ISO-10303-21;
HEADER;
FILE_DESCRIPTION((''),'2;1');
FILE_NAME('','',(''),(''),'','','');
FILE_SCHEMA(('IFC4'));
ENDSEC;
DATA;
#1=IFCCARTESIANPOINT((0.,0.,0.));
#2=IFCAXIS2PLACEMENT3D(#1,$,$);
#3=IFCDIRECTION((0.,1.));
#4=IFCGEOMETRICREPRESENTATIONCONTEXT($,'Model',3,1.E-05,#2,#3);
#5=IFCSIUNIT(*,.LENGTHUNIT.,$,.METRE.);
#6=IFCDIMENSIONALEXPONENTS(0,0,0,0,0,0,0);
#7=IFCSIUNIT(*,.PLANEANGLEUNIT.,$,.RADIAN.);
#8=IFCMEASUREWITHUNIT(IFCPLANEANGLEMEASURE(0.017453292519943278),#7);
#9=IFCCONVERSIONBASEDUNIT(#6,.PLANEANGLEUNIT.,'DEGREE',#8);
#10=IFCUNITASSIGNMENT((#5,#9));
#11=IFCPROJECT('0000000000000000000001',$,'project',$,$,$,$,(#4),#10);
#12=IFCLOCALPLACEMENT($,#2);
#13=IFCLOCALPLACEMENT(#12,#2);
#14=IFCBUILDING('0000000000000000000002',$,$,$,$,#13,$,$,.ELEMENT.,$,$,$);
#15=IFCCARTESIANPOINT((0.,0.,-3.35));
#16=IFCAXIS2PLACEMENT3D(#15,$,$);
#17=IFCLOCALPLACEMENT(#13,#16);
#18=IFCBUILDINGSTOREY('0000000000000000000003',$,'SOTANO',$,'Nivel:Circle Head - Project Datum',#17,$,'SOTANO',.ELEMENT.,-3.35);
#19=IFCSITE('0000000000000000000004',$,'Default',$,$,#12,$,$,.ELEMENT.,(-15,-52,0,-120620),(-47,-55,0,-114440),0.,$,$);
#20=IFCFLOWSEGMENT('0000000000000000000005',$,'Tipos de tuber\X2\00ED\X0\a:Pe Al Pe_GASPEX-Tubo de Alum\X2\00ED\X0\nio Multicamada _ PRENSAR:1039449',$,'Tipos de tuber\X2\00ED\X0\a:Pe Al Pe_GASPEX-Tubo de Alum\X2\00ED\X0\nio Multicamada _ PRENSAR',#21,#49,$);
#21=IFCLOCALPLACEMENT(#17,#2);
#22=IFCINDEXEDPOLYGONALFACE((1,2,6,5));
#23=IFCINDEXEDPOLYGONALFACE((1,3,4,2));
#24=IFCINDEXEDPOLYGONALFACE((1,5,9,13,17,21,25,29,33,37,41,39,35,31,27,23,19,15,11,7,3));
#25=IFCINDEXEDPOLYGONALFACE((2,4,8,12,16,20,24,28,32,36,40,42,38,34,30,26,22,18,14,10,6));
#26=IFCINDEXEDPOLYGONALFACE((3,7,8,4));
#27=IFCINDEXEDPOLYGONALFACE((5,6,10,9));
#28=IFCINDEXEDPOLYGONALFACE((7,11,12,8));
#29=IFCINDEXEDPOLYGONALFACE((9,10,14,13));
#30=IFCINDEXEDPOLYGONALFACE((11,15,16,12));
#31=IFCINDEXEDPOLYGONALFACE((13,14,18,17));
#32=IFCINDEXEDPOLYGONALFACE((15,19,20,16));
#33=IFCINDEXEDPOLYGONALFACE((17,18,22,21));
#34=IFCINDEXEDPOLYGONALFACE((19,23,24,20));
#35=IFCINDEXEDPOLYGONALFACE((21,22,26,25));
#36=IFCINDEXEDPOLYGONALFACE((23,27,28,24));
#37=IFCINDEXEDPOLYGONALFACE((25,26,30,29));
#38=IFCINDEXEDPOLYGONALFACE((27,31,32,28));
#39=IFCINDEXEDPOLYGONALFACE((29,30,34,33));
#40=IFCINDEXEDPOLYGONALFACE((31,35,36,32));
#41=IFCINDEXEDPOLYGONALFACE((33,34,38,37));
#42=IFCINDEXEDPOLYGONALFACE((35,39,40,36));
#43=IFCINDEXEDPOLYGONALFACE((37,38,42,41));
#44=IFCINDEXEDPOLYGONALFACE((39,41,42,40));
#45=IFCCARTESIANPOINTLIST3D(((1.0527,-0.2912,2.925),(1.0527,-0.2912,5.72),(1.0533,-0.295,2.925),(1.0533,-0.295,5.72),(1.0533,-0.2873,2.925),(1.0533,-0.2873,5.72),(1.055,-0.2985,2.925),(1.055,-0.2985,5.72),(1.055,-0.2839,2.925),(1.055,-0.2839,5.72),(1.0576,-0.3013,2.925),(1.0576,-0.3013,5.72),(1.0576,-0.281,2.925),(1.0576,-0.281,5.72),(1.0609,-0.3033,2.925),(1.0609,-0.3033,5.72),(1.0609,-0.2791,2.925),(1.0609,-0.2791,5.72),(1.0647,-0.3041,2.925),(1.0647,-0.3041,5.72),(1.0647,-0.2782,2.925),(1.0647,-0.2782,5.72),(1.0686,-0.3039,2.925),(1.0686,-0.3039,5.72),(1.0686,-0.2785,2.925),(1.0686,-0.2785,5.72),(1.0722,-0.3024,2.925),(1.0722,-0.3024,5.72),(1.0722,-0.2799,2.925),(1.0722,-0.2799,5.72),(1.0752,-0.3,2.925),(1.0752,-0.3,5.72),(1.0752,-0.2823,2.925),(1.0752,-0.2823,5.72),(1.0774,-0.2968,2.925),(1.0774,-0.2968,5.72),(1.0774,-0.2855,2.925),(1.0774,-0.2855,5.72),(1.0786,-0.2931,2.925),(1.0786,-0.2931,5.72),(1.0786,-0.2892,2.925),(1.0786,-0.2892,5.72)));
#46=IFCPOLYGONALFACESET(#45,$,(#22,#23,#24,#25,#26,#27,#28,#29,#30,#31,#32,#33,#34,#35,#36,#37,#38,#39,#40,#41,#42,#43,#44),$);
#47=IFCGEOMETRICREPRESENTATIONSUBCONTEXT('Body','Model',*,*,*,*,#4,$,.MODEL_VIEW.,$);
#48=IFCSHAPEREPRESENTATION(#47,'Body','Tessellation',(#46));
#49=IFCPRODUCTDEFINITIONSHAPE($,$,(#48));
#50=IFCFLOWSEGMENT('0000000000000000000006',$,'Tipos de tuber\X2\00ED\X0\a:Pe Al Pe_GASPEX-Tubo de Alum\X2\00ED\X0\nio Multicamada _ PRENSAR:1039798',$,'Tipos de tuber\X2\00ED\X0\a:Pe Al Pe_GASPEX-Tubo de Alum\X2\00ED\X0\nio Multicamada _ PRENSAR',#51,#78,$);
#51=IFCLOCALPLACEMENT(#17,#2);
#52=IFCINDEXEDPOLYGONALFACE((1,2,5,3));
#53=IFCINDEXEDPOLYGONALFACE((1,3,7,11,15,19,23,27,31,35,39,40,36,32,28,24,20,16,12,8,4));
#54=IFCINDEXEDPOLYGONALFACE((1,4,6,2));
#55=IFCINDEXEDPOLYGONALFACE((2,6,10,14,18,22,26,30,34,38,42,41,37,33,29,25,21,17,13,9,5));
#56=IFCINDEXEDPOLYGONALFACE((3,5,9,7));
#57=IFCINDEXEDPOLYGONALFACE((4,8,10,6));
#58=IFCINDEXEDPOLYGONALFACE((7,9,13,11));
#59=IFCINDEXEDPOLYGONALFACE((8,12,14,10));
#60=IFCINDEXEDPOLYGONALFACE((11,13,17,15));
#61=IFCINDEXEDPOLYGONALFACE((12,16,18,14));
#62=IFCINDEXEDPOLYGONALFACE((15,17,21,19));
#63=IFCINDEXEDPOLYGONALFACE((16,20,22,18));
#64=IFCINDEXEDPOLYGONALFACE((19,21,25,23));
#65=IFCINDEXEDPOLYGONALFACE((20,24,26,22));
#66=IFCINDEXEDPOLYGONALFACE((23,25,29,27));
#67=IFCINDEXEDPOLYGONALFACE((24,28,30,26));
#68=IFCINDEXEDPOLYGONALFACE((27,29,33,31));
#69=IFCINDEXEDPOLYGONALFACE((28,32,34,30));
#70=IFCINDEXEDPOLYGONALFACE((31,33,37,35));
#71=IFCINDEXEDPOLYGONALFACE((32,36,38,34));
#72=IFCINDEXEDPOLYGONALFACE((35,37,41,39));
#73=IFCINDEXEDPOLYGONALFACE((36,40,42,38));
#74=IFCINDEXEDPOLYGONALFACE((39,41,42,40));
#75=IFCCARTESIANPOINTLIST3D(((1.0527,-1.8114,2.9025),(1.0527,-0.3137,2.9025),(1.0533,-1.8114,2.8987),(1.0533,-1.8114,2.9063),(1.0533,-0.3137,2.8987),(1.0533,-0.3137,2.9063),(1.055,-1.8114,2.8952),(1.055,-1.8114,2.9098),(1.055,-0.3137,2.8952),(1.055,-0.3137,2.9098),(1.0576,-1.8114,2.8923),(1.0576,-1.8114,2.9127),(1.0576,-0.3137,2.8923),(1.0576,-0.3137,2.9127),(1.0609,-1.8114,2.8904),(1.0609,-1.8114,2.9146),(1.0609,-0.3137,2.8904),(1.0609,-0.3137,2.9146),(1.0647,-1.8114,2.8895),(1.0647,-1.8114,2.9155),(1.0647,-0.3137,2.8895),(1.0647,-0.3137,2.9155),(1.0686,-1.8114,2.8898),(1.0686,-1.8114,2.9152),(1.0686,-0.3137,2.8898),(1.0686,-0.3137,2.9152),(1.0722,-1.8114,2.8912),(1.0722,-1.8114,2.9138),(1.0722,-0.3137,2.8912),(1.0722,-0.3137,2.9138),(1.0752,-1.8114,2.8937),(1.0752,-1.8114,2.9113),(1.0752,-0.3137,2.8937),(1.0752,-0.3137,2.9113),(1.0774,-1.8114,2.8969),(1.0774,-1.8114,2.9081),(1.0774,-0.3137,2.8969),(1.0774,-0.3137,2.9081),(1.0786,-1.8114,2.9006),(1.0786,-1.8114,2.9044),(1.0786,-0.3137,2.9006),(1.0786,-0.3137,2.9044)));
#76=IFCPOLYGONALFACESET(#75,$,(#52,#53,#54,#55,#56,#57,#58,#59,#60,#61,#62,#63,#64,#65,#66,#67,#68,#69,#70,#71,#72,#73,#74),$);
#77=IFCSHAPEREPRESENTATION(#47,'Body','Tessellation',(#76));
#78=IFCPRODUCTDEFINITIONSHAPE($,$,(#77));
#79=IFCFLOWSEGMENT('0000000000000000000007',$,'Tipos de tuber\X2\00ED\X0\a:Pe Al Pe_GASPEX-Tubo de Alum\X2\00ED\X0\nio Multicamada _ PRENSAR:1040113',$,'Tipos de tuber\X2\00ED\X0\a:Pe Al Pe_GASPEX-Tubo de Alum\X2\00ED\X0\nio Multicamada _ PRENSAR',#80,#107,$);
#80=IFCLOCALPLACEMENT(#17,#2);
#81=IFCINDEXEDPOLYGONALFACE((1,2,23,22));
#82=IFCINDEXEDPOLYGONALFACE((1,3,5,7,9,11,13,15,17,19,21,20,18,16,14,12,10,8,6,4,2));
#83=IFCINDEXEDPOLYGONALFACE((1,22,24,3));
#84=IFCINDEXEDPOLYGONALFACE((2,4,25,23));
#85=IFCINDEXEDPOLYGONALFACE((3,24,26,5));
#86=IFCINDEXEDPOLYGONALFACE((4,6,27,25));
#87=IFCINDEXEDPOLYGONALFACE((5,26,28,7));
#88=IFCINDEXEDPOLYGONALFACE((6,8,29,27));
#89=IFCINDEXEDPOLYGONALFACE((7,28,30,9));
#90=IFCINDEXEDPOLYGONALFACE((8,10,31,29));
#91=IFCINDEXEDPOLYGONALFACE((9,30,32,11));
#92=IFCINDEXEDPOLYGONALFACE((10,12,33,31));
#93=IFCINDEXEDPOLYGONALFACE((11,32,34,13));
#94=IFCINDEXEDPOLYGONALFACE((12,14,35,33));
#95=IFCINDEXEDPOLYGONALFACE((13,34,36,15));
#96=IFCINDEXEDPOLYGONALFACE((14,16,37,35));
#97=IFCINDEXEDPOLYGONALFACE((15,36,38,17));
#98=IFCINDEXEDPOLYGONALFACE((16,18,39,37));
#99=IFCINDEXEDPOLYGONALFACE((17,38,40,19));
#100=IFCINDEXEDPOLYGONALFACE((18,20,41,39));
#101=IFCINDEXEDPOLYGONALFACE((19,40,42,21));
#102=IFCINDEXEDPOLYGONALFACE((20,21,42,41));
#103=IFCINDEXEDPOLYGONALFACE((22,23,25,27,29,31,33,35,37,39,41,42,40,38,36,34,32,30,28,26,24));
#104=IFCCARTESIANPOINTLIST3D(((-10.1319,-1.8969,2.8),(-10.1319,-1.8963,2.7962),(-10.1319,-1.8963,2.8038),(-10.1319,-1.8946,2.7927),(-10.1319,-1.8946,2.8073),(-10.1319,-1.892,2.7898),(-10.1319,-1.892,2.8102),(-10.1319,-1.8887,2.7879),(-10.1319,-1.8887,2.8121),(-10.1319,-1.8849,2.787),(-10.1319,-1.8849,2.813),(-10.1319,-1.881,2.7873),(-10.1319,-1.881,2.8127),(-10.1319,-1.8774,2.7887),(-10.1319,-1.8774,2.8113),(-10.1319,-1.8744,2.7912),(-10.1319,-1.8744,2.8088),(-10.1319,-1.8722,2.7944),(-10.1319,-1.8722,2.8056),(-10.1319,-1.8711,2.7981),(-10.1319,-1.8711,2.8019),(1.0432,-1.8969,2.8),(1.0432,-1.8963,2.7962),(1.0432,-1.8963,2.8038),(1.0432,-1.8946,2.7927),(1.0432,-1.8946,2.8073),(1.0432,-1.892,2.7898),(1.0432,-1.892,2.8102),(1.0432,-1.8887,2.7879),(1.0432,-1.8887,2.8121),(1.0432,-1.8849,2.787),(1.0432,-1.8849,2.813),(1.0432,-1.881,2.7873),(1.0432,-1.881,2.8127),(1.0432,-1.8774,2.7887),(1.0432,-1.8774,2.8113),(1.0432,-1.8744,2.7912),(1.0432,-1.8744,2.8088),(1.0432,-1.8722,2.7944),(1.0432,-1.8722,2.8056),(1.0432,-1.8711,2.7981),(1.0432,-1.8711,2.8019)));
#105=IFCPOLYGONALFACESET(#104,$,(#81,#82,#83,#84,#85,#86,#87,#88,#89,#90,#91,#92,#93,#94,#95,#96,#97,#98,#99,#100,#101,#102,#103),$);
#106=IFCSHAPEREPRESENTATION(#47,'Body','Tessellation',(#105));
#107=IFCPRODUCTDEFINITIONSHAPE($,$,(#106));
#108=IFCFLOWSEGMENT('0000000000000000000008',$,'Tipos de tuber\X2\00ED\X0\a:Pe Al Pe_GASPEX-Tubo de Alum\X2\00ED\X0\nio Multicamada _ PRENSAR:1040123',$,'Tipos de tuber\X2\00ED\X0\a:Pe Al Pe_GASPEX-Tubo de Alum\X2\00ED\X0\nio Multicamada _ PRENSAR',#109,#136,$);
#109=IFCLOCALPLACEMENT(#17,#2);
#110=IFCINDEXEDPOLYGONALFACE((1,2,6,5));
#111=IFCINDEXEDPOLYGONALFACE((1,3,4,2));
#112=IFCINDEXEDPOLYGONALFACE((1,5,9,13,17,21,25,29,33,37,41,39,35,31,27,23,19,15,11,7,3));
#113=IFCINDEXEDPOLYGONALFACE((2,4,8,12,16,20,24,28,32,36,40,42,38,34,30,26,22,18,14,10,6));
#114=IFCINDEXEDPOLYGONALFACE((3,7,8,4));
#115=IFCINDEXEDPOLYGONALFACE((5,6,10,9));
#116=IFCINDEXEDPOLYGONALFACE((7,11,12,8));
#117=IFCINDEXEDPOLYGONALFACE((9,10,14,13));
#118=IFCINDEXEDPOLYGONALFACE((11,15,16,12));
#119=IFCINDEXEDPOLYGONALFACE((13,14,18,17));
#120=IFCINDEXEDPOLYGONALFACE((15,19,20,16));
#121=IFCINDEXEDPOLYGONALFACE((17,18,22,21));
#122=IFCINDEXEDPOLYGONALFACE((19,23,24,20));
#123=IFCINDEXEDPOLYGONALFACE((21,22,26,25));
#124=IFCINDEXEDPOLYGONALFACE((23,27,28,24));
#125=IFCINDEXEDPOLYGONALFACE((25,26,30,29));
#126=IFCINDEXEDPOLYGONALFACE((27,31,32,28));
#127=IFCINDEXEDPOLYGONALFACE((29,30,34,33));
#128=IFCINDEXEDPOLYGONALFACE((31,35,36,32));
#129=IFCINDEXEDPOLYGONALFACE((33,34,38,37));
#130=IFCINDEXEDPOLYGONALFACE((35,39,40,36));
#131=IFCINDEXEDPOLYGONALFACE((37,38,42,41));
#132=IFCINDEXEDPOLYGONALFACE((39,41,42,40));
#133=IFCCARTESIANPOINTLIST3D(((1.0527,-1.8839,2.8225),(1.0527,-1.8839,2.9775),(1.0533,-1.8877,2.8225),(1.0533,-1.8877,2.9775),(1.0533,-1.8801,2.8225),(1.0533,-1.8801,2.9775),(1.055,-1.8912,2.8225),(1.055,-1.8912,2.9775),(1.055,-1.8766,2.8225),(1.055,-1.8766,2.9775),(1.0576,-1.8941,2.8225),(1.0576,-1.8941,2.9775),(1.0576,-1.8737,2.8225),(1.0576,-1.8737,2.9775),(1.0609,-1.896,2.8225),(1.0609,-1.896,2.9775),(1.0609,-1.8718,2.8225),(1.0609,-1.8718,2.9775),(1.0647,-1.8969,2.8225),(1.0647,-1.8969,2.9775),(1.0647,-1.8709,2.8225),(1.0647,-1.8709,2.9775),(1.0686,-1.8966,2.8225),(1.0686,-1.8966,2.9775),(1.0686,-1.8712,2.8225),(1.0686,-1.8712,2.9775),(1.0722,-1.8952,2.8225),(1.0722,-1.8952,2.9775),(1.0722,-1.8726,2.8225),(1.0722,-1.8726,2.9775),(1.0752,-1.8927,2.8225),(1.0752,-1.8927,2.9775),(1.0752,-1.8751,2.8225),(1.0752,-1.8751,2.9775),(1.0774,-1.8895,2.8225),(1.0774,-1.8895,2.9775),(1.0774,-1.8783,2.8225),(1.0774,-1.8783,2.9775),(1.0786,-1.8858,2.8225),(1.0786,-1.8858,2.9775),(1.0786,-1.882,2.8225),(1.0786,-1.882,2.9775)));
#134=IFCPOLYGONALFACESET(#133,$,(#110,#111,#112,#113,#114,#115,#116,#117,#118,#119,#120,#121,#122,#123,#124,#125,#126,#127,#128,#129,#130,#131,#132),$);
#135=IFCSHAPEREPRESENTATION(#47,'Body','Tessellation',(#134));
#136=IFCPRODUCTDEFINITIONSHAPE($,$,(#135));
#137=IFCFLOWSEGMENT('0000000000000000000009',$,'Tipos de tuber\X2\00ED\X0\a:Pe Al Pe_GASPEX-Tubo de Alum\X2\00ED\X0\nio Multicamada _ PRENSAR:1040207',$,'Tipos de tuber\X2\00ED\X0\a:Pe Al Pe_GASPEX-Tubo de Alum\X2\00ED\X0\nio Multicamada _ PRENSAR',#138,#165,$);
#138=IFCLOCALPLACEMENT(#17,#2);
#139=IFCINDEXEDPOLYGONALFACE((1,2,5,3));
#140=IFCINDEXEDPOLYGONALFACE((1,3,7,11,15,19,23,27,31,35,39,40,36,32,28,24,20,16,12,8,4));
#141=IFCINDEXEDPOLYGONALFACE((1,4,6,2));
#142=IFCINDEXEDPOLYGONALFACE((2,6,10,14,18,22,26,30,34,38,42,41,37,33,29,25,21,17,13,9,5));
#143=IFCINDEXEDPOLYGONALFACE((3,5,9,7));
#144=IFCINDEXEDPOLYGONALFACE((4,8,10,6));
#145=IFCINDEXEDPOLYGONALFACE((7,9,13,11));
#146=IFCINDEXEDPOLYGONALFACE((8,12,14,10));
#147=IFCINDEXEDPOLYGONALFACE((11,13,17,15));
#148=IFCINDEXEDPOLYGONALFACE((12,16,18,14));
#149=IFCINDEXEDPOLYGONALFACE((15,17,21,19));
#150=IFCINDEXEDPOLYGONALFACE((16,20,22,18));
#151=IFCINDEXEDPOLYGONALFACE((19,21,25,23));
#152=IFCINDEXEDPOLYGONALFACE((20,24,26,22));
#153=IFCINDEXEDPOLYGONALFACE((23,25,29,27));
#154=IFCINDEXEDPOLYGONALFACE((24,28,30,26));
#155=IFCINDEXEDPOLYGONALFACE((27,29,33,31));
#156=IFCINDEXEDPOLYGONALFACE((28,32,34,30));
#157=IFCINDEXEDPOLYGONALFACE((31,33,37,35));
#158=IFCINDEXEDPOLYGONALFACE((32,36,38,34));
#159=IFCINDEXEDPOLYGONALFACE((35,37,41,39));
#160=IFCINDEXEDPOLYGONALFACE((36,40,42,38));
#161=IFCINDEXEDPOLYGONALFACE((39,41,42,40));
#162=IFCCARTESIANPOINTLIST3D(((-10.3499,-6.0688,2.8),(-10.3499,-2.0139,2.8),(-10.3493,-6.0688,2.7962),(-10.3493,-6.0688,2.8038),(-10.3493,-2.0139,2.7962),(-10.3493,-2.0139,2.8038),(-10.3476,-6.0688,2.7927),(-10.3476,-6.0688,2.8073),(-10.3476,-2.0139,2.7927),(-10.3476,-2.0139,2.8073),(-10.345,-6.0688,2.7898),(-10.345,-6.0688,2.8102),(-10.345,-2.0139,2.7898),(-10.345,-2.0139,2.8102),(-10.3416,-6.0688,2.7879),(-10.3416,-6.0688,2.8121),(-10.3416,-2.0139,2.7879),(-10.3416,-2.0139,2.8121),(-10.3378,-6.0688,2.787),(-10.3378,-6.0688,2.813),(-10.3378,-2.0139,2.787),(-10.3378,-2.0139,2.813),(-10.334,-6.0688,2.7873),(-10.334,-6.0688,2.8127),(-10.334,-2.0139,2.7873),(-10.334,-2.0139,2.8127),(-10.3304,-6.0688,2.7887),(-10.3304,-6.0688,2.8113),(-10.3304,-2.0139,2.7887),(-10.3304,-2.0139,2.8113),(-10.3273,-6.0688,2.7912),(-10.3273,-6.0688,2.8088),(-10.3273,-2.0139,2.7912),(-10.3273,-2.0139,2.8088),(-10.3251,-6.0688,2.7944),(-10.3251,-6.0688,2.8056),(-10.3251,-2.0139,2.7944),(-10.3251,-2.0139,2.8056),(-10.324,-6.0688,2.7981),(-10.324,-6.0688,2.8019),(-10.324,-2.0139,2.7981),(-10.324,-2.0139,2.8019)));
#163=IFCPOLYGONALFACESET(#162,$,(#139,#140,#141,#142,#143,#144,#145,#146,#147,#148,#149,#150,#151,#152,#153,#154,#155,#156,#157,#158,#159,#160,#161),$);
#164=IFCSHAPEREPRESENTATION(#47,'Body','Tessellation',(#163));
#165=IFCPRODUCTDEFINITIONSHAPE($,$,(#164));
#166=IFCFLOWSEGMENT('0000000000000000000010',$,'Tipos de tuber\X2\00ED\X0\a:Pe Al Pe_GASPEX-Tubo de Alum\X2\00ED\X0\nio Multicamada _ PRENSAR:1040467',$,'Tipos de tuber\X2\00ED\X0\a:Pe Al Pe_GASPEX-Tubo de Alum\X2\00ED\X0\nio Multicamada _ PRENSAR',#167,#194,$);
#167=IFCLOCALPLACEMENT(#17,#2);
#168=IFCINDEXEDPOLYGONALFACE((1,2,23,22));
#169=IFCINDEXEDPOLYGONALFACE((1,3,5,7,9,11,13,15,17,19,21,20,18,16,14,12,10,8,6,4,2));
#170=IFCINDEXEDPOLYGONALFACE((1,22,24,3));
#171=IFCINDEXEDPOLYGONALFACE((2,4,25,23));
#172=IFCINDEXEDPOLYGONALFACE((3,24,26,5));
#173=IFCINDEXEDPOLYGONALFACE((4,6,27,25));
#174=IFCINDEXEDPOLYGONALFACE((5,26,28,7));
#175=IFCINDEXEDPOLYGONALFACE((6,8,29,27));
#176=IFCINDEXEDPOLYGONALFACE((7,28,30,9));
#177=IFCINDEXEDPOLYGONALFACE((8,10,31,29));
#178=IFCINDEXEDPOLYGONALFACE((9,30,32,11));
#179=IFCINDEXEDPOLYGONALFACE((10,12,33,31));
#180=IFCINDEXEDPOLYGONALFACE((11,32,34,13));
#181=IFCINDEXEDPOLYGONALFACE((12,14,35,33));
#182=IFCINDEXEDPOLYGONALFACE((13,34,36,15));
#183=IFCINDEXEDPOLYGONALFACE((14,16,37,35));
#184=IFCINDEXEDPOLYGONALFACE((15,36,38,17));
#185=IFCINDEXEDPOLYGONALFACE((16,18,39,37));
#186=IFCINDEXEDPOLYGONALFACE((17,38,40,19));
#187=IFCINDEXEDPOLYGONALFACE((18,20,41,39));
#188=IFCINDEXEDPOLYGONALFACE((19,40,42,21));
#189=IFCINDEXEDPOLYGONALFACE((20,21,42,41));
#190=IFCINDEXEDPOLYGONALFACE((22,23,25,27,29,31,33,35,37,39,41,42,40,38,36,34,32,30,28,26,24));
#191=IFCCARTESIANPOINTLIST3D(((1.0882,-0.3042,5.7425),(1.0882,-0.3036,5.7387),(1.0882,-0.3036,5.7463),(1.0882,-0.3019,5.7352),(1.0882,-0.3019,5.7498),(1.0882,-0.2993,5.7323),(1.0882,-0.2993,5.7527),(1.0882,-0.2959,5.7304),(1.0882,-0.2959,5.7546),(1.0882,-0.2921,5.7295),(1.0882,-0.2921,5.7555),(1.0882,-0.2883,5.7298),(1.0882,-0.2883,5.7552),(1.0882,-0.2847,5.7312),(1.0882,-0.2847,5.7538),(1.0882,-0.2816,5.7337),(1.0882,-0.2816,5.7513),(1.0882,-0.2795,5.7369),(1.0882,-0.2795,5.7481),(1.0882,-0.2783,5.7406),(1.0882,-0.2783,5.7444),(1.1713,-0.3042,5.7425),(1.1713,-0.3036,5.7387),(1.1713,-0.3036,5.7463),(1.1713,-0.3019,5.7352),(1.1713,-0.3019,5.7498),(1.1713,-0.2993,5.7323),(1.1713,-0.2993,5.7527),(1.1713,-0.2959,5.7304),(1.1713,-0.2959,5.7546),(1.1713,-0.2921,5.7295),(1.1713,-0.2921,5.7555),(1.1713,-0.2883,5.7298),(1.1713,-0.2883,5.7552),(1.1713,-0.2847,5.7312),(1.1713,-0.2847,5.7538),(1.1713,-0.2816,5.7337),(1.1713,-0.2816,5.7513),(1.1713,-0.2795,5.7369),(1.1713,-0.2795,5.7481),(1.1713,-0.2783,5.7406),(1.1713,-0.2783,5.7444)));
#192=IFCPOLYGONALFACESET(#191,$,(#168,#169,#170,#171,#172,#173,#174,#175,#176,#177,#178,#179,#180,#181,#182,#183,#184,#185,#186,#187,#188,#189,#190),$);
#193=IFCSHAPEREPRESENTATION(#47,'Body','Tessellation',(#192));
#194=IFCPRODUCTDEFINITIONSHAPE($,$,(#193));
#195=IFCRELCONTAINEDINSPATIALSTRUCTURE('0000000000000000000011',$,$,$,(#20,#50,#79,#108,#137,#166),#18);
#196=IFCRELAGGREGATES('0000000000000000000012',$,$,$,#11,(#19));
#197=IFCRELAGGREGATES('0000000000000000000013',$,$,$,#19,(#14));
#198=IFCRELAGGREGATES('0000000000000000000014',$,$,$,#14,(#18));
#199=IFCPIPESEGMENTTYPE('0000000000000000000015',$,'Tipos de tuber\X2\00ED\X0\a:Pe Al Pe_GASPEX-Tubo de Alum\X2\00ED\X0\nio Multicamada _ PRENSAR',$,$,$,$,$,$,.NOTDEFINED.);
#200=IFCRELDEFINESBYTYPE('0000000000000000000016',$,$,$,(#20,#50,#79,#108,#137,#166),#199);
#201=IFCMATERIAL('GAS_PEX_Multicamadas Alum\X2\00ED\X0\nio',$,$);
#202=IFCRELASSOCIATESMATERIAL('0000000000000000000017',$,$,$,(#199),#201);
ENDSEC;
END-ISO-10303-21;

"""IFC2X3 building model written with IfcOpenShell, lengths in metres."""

from ifc_helpers import new_model, entity, si_unit, converted_unit, direction, frame, frame_2d, origin, origin_2d_with_axis, place, context, subcontext, project, spatial, circle, extrude, material, type_object, element, save


model = new_model("IFC2X3")

# Units and contexts
model_context = context("Model", 3, precision=1e-05, world=origin(), true_north=direction((0.0, 1.0)))
body_context = subcontext(model_context, "Body", "Model", "MODEL_VIEW")
ifc_project = project(units=[si_unit("LENGTHUNIT", "METRE"), converted_unit("PLANEANGLEUNIT", "DEGREE", entity("IfcPlaneAngleMeasure", 0.017453292519943278), si_unit("PLANEANGLEUNIT", "RADIAN"), dimensions=[0, 0, 0, 0, 0, 0, 0])], contexts=[model_context])

# Site, building, storey
site_placement = place(None, origin())
site = spatial("IfcSite", under=ifc_project, at=site_placement, Name="Default", CompositionType="ELEMENT", RefLatitude=(-15, -52, 0, -120620), RefLongitude=(-47, -55, 0, -114440), RefElevation=0.0)
building_placement = place(site_placement, origin())
building = spatial("IfcBuilding", under=site, at=building_placement, CompositionType="ELEMENT")
storey_placement = place(building_placement, frame((0.0, 0.0, -3.35)))
storey = spatial("IfcBuildingStorey", under=building, at=storey_placement, Name="SOTANO", ObjectType="Nivel:Circle Head - Project Datum", LongName="SOTANO", CompositionType="ELEMENT", Elevation=-3.35)

# Flow segments
ifc_material = material(Name="GAS_PEX_Multicamadas Alumínio")
pipe_segment_type_1 = type_object("IfcPipeSegmentType", Name="Tipos de tubería:Pe Al Pe_GASPEX-Tubo de Alumínio Multicamada _ PRENSAR", PredefinedType="NOTDEFINED", material=ifc_material)
flow_segment_1_placement = place(storey_placement, origin())
element("IfcFlowSegment", 1, at=flow_segment_1_placement, inside=storey, type_object=pipe_segment_type_1, Name="Tipos de tubería:Pe Al Pe_GASPEX-Tubo de Alumínio Multicamada _ PRENSAR:1039449", ObjectType="Tipos de tubería:Pe Al Pe_GASPEX-Tubo de Alumínio Multicamada _ PRENSAR", context=body_context, shape_type="SweptSolid", body=[
    extrude(circle(Radius=0.013, at=origin_2d_with_axis()), frame((1.0657, -0.2912, 2.925), z_axis=(0.0, 0.0, 1.0), x_axis=(-1.0, 0.0, 0.0)), (0.0, 0.0, 1.0), 2.795),
])
flow_segment_2_placement = place(storey_placement, origin())
element("IfcFlowSegment", 2, at=flow_segment_2_placement, inside=storey, type_object=pipe_segment_type_1, Name="Tipos de tubería:Pe Al Pe_GASPEX-Tubo de Alumínio Multicamada _ PRENSAR:1039798", ObjectType="Tipos de tubería:Pe Al Pe_GASPEX-Tubo de Alumínio Multicamada _ PRENSAR", context=body_context, shape_type="SweptSolid", body=[
    extrude(circle(Radius=0.013, at=frame_2d((0.0, 0.0), x_axis=(1.0, 0.0))), frame((1.0657, -1.8114, 2.9025), z_axis=(0.0, 1.0, 0.0), x_axis=(-1.0, 0.0, 0.0)), (0.0, 0.0, 1.0), 1.4977),
])
flow_segment_3_placement = place(storey_placement, origin())
element("IfcFlowSegment", 3, at=flow_segment_3_placement, inside=storey, type_object=pipe_segment_type_1, Name="Tipos de tubería:Pe Al Pe_GASPEX-Tubo de Alumínio Multicamada _ PRENSAR:1040113", ObjectType="Tipos de tubería:Pe Al Pe_GASPEX-Tubo de Alumínio Multicamada _ PRENSAR", context=body_context, shape_type="SweptSolid", body=[
    extrude(circle(Radius=0.013, at=origin_2d_with_axis()), frame((-10.1319, -1.8839, 2.8), z_axis=(1.0, 0.0, 0.0), x_axis=(0.0, -1.0, 0.0)), (0.0, 0.0, 1.0), 11.1751),
])
flow_segment_4_placement = place(storey_placement, origin())
element("IfcFlowSegment", 4, at=flow_segment_4_placement, inside=storey, type_object=pipe_segment_type_1, Name="Tipos de tubería:Pe Al Pe_GASPEX-Tubo de Alumínio Multicamada _ PRENSAR:1040123", ObjectType="Tipos de tubería:Pe Al Pe_GASPEX-Tubo de Alumínio Multicamada _ PRENSAR", context=body_context, shape_type="SweptSolid", body=[
    extrude(circle(Radius=0.013, at=frame_2d((0.0, 0.0), x_axis=(1.0, 0.0))), frame((1.0657, -1.8839, 2.8225), z_axis=(0.0, 0.0, 1.0), x_axis=(-1.0, 0.0, 0.0)), (0.0, 0.0, 1.0), 0.155),
])
flow_segment_5_placement = place(storey_placement, origin())
element("IfcFlowSegment", 5, at=flow_segment_5_placement, inside=storey, type_object=pipe_segment_type_1, Name="Tipos de tubería:Pe Al Pe_GASPEX-Tubo de Alumínio Multicamada _ PRENSAR:1040207", ObjectType="Tipos de tubería:Pe Al Pe_GASPEX-Tubo de Alumínio Multicamada _ PRENSAR", context=body_context, shape_type="SweptSolid", body=[
    extrude(circle(Radius=0.013, at=frame_2d((0.0, 0.0), x_axis=(1.0, 0.0))), frame((-10.3369, -6.0688, 2.8), z_axis=(0.0, 1.0, 0.0), x_axis=(-1.0, 0.0, 0.0)), (0.0, 0.0, 1.0), 4.0549),
])
flow_segment_6_placement = place(storey_placement, origin())
element("IfcFlowSegment", 6, at=flow_segment_6_placement, inside=storey, type_object=pipe_segment_type_1, Name="Tipos de tubería:Pe Al Pe_GASPEX-Tubo de Alumínio Multicamada _ PRENSAR:1040467", ObjectType="Tipos de tubería:Pe Al Pe_GASPEX-Tubo de Alumínio Multicamada _ PRENSAR", context=body_context, shape_type="SweptSolid", body=[
    extrude(circle(Radius=0.013, at=frame_2d((0.0, 0.0), x_axis=(1.0, 0.0))), frame((1.0882, -0.2912, 5.7425), z_axis=(1.0, 0.0, 0.0), x_axis=(0.0, -1.0, 0.0)), (0.0, 0.0, 1.0), 0.0831),
])

save(model, "model.ifc")
